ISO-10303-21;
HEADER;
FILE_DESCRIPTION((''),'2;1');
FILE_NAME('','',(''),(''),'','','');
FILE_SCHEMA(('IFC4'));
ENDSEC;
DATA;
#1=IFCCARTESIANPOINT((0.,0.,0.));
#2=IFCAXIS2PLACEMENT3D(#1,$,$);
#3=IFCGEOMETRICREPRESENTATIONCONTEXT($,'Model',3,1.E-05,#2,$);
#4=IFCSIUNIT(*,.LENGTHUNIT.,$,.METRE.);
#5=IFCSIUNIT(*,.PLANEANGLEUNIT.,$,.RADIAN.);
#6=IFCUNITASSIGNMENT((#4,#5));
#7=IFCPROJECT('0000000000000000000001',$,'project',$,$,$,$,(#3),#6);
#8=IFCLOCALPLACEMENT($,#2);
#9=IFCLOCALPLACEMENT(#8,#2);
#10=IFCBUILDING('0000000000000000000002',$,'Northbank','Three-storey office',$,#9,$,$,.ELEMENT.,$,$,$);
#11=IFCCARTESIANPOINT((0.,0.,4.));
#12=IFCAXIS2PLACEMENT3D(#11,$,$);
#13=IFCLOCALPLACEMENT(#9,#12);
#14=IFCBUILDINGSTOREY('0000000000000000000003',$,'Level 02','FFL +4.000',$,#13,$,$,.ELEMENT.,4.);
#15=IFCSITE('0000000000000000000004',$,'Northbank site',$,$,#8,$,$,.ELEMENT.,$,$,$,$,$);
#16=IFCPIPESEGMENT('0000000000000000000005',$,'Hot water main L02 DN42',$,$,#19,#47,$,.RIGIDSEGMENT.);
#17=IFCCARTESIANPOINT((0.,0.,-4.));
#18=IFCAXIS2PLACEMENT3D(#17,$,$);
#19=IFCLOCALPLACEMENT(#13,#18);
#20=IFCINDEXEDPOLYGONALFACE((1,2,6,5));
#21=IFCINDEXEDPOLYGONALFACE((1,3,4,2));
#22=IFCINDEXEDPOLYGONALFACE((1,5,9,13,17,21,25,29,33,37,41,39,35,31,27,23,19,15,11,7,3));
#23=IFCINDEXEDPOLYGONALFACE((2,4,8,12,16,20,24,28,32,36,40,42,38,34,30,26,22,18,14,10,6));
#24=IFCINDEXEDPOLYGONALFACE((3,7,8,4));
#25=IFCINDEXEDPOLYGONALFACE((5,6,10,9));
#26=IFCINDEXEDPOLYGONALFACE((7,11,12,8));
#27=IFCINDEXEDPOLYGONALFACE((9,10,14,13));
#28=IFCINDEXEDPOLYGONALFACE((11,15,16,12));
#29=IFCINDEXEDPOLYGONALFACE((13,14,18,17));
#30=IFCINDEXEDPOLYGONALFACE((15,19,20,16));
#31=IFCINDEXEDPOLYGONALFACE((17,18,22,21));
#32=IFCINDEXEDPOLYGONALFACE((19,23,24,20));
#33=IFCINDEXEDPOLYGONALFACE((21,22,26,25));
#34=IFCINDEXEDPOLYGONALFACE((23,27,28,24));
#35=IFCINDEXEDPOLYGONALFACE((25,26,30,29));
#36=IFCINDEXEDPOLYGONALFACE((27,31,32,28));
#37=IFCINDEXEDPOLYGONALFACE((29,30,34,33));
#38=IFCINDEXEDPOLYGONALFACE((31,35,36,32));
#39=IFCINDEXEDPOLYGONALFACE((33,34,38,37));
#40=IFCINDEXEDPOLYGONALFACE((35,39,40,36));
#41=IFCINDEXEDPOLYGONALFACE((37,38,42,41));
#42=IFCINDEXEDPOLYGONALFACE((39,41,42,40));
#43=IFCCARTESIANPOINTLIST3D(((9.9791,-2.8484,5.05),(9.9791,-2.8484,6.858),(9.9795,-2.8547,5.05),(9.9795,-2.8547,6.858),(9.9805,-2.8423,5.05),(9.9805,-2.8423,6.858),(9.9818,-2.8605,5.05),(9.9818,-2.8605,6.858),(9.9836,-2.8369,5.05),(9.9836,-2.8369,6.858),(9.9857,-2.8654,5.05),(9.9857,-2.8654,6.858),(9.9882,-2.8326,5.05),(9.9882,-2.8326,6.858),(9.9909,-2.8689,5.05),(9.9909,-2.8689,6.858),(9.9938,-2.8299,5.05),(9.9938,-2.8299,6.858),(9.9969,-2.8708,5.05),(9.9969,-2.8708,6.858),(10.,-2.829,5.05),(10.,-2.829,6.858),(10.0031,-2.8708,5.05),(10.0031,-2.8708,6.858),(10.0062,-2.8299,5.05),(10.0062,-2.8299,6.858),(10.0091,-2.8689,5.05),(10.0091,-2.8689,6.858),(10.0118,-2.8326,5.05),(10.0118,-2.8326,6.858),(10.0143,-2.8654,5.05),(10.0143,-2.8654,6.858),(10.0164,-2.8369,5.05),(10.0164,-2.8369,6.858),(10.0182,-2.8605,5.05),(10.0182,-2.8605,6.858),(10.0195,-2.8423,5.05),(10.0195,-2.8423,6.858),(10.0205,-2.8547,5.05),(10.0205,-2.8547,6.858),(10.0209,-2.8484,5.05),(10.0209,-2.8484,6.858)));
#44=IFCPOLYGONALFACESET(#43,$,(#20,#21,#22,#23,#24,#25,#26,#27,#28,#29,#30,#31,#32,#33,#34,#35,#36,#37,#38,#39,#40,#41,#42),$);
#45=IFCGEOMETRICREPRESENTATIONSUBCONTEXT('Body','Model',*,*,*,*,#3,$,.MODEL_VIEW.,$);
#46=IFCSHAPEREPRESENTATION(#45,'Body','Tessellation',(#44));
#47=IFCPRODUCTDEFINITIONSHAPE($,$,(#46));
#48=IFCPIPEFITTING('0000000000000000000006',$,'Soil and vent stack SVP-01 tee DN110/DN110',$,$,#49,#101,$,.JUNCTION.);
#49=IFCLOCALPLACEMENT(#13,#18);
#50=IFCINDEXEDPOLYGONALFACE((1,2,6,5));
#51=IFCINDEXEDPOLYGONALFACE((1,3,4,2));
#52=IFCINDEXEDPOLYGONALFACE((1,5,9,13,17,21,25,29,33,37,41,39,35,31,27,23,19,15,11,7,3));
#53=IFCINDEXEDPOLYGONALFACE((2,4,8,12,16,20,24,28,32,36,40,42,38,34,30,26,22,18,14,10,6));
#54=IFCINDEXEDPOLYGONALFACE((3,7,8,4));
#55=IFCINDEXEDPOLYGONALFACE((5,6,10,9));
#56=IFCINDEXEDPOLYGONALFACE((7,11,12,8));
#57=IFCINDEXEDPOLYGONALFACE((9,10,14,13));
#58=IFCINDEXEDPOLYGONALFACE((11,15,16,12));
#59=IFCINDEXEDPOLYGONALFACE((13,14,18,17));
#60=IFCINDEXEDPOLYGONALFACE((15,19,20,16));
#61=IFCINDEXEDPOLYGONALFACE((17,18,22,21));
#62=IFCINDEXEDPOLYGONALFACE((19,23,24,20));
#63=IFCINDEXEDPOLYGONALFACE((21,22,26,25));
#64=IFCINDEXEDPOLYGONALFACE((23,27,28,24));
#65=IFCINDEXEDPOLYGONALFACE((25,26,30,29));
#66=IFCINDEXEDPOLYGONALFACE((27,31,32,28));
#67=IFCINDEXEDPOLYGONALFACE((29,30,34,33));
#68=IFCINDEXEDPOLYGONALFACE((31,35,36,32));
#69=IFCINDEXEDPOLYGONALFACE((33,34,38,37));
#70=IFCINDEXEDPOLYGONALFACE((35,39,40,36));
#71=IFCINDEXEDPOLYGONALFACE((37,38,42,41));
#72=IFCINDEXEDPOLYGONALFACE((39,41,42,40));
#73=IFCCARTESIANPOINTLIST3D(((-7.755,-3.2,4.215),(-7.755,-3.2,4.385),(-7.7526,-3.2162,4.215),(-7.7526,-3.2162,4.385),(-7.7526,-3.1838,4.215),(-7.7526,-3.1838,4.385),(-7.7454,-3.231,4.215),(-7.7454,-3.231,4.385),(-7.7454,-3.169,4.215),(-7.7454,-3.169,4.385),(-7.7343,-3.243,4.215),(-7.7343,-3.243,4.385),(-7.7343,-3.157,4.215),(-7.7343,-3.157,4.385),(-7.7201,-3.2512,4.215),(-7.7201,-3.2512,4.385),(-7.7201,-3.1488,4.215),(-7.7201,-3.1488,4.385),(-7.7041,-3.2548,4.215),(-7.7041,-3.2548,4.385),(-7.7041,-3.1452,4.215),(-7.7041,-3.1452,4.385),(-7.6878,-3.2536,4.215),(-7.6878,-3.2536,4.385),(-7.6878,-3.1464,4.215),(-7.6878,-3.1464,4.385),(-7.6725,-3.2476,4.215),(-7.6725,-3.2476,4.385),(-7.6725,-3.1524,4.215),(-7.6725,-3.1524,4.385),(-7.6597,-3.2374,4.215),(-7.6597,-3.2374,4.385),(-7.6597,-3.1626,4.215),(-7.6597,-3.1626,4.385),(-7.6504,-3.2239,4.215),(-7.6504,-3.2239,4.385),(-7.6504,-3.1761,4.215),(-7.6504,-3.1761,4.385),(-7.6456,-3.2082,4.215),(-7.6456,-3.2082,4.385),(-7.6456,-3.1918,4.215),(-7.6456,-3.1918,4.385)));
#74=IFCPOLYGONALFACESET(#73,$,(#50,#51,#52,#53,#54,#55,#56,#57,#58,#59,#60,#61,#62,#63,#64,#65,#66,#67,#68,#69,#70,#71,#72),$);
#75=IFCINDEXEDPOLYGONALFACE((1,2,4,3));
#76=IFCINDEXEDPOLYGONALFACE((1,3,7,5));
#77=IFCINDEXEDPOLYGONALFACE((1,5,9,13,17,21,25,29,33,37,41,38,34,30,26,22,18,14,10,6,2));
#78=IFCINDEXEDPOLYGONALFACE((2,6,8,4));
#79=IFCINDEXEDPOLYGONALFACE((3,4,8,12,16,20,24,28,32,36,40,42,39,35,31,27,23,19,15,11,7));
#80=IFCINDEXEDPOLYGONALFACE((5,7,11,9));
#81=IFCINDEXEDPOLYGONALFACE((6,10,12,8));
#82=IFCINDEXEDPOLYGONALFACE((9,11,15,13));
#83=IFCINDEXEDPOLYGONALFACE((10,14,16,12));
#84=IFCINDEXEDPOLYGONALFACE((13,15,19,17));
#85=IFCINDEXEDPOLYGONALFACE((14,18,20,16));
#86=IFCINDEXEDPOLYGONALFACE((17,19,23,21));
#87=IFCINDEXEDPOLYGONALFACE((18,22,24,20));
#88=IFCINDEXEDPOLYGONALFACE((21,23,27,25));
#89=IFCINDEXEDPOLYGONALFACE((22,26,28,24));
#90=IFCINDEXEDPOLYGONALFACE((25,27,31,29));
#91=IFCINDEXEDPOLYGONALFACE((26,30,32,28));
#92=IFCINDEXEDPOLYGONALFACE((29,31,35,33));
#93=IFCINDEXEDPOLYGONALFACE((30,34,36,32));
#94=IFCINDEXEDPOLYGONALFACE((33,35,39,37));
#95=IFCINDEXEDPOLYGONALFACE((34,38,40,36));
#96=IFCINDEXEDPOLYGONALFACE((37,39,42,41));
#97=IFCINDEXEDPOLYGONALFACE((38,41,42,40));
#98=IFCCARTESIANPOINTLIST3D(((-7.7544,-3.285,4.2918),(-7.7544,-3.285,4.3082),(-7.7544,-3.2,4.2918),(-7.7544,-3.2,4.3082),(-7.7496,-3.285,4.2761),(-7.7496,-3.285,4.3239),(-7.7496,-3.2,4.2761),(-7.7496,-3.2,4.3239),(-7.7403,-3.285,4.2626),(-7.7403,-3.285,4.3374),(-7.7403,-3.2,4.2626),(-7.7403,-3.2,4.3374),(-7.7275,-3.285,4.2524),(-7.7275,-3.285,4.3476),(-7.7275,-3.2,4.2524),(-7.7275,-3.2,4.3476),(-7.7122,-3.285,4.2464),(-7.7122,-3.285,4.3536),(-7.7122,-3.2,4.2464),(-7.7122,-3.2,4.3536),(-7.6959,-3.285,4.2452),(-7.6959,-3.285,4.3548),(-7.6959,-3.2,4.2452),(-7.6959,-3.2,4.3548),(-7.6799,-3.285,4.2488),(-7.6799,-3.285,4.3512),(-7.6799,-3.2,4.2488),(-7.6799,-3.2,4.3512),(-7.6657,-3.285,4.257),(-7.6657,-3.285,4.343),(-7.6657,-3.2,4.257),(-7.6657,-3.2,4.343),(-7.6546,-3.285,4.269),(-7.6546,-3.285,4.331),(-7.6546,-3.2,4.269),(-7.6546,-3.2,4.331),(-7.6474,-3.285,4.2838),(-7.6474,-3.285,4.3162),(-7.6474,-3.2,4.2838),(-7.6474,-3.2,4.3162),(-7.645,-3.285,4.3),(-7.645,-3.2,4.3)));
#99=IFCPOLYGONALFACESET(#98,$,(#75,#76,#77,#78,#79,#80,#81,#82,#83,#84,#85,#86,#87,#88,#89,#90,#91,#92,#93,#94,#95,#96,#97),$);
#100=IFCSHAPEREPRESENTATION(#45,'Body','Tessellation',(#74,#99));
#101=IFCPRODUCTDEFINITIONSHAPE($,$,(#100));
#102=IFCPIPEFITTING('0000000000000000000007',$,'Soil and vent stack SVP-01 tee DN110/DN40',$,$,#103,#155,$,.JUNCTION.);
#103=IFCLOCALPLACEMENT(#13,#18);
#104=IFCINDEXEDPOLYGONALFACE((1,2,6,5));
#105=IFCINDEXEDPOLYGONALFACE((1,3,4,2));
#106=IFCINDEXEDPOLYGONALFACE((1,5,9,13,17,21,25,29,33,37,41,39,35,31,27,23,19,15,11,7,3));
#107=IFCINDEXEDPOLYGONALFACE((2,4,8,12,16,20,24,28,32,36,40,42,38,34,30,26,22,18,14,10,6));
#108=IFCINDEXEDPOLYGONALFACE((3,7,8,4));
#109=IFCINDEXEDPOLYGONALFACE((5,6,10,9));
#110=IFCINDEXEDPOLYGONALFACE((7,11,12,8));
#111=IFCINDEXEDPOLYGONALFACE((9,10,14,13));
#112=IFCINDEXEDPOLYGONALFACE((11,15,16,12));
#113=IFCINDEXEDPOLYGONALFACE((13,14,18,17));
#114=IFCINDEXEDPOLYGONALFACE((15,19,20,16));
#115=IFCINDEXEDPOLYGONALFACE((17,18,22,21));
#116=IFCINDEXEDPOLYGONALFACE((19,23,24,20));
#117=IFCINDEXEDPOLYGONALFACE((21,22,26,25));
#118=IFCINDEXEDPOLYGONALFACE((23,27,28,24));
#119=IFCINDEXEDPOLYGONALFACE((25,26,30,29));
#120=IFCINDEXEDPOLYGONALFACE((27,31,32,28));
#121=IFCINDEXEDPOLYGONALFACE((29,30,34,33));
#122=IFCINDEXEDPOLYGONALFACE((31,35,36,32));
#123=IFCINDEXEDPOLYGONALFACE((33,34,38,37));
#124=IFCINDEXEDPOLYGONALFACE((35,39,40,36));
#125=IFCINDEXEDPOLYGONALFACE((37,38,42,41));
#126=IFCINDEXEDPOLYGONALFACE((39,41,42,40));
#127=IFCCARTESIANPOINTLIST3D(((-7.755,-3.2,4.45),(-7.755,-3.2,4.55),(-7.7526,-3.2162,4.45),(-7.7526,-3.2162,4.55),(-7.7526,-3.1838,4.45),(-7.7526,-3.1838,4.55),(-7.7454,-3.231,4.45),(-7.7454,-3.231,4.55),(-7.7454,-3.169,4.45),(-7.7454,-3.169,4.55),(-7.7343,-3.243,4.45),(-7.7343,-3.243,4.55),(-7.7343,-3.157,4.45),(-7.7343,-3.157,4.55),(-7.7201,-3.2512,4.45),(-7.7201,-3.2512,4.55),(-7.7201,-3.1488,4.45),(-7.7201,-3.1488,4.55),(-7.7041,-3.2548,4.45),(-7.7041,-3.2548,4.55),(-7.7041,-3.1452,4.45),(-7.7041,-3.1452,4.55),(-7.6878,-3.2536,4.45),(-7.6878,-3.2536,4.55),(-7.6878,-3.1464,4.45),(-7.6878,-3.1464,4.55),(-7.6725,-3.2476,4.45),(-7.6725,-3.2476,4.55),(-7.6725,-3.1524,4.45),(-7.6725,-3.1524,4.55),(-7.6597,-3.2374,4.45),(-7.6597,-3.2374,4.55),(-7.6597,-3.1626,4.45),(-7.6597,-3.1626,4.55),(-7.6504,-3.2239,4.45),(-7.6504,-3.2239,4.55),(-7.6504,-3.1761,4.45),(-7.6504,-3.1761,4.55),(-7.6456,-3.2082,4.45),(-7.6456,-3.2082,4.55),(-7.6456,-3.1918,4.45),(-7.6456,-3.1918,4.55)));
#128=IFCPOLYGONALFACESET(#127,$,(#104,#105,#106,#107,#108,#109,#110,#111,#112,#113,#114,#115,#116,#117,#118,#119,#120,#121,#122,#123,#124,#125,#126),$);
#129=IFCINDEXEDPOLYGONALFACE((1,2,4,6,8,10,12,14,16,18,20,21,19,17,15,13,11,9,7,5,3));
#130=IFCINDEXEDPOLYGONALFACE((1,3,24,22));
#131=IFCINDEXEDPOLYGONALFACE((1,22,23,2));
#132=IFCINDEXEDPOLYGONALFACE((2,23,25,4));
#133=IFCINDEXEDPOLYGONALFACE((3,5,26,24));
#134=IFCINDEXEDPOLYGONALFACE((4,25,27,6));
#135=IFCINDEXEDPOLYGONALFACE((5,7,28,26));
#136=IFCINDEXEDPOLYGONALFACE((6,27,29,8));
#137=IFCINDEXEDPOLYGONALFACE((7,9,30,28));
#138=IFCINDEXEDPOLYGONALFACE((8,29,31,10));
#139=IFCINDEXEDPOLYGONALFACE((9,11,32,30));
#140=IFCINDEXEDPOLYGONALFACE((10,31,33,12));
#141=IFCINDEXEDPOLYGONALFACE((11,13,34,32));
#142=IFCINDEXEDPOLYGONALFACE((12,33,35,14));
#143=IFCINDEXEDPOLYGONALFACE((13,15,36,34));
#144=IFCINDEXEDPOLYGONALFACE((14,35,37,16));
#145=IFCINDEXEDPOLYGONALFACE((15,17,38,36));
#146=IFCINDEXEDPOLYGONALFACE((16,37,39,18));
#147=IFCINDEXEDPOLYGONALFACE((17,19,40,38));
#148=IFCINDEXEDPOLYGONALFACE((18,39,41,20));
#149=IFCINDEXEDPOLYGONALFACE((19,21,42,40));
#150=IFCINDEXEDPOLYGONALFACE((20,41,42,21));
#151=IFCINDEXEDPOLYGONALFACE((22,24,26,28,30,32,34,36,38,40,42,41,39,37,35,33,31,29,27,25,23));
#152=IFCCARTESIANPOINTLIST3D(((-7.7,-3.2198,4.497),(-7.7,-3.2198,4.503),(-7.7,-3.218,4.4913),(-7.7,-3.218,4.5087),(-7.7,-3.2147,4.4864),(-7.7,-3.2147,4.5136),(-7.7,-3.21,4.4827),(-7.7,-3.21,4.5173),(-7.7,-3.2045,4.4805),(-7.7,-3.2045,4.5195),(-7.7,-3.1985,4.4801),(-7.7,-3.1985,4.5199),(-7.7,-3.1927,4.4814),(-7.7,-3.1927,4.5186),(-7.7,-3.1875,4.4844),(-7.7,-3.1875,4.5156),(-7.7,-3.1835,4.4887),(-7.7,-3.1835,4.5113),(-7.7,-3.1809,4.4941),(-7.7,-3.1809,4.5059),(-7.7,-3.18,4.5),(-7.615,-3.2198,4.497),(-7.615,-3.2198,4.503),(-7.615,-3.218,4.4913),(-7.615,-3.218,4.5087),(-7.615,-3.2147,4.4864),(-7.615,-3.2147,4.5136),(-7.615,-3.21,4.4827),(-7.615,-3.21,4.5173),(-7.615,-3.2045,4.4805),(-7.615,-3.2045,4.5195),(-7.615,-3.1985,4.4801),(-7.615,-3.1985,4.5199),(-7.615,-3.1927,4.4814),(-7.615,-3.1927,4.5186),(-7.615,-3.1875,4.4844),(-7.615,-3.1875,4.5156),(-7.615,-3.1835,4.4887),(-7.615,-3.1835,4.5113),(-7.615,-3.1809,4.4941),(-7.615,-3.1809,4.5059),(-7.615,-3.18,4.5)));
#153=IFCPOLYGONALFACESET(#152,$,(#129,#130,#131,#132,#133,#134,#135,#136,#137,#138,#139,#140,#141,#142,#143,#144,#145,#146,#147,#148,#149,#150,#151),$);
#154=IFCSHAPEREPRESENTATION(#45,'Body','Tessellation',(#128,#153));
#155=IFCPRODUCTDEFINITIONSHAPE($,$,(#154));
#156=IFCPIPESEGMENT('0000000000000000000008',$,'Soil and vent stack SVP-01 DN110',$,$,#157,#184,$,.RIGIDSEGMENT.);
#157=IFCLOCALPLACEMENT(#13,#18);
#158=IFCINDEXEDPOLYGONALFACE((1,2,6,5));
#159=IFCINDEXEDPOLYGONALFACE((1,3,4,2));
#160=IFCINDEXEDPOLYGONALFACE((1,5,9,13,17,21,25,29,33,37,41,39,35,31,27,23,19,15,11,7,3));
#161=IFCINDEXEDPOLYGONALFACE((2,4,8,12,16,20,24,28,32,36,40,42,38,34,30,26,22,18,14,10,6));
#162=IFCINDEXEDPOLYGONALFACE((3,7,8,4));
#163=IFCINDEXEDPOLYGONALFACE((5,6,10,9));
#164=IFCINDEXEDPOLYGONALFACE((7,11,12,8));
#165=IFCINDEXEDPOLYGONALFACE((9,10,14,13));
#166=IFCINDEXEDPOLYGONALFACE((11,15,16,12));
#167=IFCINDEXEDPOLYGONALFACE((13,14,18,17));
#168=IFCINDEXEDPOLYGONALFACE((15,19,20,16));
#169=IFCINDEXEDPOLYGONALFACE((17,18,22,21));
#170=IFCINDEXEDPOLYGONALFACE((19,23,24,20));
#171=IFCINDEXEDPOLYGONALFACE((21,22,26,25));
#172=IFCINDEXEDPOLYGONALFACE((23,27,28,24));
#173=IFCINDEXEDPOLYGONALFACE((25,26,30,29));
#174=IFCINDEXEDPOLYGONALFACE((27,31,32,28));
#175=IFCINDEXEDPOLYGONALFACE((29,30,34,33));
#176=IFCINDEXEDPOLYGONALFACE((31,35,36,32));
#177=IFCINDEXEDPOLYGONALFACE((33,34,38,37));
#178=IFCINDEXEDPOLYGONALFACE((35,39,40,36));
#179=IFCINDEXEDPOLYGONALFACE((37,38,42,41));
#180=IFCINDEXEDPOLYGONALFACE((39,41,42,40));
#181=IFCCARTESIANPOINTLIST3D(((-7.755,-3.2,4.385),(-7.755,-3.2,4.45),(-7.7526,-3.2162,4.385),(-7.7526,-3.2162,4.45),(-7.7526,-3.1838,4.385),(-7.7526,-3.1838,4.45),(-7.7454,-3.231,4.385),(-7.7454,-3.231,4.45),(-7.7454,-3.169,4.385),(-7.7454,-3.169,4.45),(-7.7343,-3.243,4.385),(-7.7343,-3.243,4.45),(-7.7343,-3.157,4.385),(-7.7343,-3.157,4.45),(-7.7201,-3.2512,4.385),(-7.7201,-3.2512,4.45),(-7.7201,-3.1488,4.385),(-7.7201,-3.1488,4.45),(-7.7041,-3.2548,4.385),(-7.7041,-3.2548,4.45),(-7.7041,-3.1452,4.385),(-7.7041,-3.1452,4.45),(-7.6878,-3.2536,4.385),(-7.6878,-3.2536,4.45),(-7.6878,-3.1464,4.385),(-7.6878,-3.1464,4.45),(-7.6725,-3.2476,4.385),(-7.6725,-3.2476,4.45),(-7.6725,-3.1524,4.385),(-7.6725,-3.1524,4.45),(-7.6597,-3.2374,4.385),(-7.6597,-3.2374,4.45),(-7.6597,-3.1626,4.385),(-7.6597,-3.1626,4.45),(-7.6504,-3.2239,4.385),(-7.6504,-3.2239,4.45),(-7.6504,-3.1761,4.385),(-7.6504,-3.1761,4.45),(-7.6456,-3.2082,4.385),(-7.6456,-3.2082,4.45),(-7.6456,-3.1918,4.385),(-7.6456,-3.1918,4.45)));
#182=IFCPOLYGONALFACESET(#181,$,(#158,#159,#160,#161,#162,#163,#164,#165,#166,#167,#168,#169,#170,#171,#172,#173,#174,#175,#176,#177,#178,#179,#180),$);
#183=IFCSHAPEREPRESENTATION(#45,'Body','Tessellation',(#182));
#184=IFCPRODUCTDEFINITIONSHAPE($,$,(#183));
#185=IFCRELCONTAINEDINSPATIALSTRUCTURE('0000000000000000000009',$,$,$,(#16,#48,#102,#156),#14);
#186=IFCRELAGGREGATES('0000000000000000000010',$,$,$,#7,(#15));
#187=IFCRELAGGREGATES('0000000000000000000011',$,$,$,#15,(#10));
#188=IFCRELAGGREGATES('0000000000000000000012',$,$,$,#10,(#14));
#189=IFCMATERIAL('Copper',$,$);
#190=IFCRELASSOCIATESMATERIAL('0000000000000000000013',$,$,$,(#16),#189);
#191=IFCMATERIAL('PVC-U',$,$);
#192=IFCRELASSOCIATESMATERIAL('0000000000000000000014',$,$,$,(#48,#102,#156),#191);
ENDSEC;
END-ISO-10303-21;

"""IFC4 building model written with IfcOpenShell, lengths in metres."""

from ifc_helpers import new_model, si_unit, frame, origin, place, context, subcontext, project, spatial, circle, extrude, material, element, save


model = new_model("IFC4")

# Units and contexts
model_context = context("Model", 3, precision=1e-05, world=origin())
body_context = subcontext(model_context, "Body", "Model", "MODEL_VIEW")
ifc_project = project(units=[si_unit("LENGTHUNIT", "METRE"), si_unit("PLANEANGLEUNIT", "RADIAN")], contexts=[model_context])

# Site, building, storey
site_placement = place(None, origin())
site = spatial("IfcSite", under=ifc_project, at=site_placement, Name="Northbank site", CompositionType="ELEMENT")
building_placement = place(site_placement, origin())
building = spatial("IfcBuilding", under=site, at=building_placement, Name="Northbank", Description="Three-storey office", CompositionType="ELEMENT")
storey_placement = place(building_placement, frame((0.0, 0.0, 4.0)))
storey = spatial("IfcBuildingStorey", under=building, at=storey_placement, Name="Level 02", Description="FFL +4.000", CompositionType="ELEMENT", Elevation=4.0)

# Pipe segment
ifc_material_1 = material(Name="Copper")
pipe_segment_1_placement = place(storey_placement, frame((0.0, 0.0, -4.0)))
element("IfcPipeSegment", 1, at=pipe_segment_1_placement, inside=storey, material=ifc_material_1, Name="Hot water main L02 DN42", PredefinedType="RIGIDSEGMENT", context=body_context, shape_type="SweptSolid", body=[
    extrude(circle(Radius=0.021), frame((10.0, -2.85, 6.858), z_axis=(0.0, 0.0, -1.0), x_axis=(0.0, 1.0, 0.0)), (0.0, 0.0, 1.0), 1.808),
])

# Pipe fittings
ifc_material_2 = material(Name="PVC-U")
pipe_fitting_1_placement = place(storey_placement, frame((0.0, 0.0, -4.0)))
element("IfcPipeFitting", 2, at=pipe_fitting_1_placement, inside=storey, material=ifc_material_2, Name="Soil and vent stack SVP-01 tee DN110/DN110", PredefinedType="JUNCTION", context=body_context, shape_type="SweptSolid", body=[
    extrude(circle(Radius=0.055), frame((-7.7, -3.2, 4.215), z_axis=(0.0, 0.0, 1.0), x_axis=(-1.0, 0.0, 0.0)), (0.0, 0.0, 1.0), 0.17),
    extrude(circle(Radius=0.055), frame((-7.7, -3.2, 4.3), z_axis=(0.0, -1.0, 0.0), x_axis=(1.0, 0.0, 0.0)), (0.0, 0.0, 1.0), 0.085),
])
pipe_fitting_2_placement = place(storey_placement, frame((0.0, 0.0, -4.0)))
element("IfcPipeFitting", 3, at=pipe_fitting_2_placement, inside=storey, material=ifc_material_2, Name="Soil and vent stack SVP-01 tee DN110/DN40", PredefinedType="JUNCTION", context=body_context, shape_type="SweptSolid", body=[
    extrude(circle(Radius=0.055), frame((-7.7, -3.2, 4.45), z_axis=(0.0, 0.0, 1.0), x_axis=(-1.0, 0.0, 0.0)), (0.0, 0.0, 1.0), 0.1),
    extrude(circle(Radius=0.02), frame((-7.7, -3.2, 4.5), z_axis=(1.0, 0.0, 0.0), x_axis=(0.0, 1.0, 0.0)), (0.0, 0.0, 1.0), 0.085),
])

# Pipe segment
pipe_segment_2_placement = place(storey_placement, frame((0.0, 0.0, -4.0)))
element("IfcPipeSegment", 4, at=pipe_segment_2_placement, inside=storey, material=ifc_material_2, Name="Soil and vent stack SVP-01 DN110", PredefinedType="RIGIDSEGMENT", context=body_context, shape_type="SweptSolid", body=[
    extrude(circle(Radius=0.055), frame((-7.7, -3.2, 4.385), z_axis=(0.0, 0.0, 1.0), x_axis=(-1.0, 0.0, 0.0)), (0.0, 0.0, 1.0), 0.065),
])

save(model, "model.ifc")
